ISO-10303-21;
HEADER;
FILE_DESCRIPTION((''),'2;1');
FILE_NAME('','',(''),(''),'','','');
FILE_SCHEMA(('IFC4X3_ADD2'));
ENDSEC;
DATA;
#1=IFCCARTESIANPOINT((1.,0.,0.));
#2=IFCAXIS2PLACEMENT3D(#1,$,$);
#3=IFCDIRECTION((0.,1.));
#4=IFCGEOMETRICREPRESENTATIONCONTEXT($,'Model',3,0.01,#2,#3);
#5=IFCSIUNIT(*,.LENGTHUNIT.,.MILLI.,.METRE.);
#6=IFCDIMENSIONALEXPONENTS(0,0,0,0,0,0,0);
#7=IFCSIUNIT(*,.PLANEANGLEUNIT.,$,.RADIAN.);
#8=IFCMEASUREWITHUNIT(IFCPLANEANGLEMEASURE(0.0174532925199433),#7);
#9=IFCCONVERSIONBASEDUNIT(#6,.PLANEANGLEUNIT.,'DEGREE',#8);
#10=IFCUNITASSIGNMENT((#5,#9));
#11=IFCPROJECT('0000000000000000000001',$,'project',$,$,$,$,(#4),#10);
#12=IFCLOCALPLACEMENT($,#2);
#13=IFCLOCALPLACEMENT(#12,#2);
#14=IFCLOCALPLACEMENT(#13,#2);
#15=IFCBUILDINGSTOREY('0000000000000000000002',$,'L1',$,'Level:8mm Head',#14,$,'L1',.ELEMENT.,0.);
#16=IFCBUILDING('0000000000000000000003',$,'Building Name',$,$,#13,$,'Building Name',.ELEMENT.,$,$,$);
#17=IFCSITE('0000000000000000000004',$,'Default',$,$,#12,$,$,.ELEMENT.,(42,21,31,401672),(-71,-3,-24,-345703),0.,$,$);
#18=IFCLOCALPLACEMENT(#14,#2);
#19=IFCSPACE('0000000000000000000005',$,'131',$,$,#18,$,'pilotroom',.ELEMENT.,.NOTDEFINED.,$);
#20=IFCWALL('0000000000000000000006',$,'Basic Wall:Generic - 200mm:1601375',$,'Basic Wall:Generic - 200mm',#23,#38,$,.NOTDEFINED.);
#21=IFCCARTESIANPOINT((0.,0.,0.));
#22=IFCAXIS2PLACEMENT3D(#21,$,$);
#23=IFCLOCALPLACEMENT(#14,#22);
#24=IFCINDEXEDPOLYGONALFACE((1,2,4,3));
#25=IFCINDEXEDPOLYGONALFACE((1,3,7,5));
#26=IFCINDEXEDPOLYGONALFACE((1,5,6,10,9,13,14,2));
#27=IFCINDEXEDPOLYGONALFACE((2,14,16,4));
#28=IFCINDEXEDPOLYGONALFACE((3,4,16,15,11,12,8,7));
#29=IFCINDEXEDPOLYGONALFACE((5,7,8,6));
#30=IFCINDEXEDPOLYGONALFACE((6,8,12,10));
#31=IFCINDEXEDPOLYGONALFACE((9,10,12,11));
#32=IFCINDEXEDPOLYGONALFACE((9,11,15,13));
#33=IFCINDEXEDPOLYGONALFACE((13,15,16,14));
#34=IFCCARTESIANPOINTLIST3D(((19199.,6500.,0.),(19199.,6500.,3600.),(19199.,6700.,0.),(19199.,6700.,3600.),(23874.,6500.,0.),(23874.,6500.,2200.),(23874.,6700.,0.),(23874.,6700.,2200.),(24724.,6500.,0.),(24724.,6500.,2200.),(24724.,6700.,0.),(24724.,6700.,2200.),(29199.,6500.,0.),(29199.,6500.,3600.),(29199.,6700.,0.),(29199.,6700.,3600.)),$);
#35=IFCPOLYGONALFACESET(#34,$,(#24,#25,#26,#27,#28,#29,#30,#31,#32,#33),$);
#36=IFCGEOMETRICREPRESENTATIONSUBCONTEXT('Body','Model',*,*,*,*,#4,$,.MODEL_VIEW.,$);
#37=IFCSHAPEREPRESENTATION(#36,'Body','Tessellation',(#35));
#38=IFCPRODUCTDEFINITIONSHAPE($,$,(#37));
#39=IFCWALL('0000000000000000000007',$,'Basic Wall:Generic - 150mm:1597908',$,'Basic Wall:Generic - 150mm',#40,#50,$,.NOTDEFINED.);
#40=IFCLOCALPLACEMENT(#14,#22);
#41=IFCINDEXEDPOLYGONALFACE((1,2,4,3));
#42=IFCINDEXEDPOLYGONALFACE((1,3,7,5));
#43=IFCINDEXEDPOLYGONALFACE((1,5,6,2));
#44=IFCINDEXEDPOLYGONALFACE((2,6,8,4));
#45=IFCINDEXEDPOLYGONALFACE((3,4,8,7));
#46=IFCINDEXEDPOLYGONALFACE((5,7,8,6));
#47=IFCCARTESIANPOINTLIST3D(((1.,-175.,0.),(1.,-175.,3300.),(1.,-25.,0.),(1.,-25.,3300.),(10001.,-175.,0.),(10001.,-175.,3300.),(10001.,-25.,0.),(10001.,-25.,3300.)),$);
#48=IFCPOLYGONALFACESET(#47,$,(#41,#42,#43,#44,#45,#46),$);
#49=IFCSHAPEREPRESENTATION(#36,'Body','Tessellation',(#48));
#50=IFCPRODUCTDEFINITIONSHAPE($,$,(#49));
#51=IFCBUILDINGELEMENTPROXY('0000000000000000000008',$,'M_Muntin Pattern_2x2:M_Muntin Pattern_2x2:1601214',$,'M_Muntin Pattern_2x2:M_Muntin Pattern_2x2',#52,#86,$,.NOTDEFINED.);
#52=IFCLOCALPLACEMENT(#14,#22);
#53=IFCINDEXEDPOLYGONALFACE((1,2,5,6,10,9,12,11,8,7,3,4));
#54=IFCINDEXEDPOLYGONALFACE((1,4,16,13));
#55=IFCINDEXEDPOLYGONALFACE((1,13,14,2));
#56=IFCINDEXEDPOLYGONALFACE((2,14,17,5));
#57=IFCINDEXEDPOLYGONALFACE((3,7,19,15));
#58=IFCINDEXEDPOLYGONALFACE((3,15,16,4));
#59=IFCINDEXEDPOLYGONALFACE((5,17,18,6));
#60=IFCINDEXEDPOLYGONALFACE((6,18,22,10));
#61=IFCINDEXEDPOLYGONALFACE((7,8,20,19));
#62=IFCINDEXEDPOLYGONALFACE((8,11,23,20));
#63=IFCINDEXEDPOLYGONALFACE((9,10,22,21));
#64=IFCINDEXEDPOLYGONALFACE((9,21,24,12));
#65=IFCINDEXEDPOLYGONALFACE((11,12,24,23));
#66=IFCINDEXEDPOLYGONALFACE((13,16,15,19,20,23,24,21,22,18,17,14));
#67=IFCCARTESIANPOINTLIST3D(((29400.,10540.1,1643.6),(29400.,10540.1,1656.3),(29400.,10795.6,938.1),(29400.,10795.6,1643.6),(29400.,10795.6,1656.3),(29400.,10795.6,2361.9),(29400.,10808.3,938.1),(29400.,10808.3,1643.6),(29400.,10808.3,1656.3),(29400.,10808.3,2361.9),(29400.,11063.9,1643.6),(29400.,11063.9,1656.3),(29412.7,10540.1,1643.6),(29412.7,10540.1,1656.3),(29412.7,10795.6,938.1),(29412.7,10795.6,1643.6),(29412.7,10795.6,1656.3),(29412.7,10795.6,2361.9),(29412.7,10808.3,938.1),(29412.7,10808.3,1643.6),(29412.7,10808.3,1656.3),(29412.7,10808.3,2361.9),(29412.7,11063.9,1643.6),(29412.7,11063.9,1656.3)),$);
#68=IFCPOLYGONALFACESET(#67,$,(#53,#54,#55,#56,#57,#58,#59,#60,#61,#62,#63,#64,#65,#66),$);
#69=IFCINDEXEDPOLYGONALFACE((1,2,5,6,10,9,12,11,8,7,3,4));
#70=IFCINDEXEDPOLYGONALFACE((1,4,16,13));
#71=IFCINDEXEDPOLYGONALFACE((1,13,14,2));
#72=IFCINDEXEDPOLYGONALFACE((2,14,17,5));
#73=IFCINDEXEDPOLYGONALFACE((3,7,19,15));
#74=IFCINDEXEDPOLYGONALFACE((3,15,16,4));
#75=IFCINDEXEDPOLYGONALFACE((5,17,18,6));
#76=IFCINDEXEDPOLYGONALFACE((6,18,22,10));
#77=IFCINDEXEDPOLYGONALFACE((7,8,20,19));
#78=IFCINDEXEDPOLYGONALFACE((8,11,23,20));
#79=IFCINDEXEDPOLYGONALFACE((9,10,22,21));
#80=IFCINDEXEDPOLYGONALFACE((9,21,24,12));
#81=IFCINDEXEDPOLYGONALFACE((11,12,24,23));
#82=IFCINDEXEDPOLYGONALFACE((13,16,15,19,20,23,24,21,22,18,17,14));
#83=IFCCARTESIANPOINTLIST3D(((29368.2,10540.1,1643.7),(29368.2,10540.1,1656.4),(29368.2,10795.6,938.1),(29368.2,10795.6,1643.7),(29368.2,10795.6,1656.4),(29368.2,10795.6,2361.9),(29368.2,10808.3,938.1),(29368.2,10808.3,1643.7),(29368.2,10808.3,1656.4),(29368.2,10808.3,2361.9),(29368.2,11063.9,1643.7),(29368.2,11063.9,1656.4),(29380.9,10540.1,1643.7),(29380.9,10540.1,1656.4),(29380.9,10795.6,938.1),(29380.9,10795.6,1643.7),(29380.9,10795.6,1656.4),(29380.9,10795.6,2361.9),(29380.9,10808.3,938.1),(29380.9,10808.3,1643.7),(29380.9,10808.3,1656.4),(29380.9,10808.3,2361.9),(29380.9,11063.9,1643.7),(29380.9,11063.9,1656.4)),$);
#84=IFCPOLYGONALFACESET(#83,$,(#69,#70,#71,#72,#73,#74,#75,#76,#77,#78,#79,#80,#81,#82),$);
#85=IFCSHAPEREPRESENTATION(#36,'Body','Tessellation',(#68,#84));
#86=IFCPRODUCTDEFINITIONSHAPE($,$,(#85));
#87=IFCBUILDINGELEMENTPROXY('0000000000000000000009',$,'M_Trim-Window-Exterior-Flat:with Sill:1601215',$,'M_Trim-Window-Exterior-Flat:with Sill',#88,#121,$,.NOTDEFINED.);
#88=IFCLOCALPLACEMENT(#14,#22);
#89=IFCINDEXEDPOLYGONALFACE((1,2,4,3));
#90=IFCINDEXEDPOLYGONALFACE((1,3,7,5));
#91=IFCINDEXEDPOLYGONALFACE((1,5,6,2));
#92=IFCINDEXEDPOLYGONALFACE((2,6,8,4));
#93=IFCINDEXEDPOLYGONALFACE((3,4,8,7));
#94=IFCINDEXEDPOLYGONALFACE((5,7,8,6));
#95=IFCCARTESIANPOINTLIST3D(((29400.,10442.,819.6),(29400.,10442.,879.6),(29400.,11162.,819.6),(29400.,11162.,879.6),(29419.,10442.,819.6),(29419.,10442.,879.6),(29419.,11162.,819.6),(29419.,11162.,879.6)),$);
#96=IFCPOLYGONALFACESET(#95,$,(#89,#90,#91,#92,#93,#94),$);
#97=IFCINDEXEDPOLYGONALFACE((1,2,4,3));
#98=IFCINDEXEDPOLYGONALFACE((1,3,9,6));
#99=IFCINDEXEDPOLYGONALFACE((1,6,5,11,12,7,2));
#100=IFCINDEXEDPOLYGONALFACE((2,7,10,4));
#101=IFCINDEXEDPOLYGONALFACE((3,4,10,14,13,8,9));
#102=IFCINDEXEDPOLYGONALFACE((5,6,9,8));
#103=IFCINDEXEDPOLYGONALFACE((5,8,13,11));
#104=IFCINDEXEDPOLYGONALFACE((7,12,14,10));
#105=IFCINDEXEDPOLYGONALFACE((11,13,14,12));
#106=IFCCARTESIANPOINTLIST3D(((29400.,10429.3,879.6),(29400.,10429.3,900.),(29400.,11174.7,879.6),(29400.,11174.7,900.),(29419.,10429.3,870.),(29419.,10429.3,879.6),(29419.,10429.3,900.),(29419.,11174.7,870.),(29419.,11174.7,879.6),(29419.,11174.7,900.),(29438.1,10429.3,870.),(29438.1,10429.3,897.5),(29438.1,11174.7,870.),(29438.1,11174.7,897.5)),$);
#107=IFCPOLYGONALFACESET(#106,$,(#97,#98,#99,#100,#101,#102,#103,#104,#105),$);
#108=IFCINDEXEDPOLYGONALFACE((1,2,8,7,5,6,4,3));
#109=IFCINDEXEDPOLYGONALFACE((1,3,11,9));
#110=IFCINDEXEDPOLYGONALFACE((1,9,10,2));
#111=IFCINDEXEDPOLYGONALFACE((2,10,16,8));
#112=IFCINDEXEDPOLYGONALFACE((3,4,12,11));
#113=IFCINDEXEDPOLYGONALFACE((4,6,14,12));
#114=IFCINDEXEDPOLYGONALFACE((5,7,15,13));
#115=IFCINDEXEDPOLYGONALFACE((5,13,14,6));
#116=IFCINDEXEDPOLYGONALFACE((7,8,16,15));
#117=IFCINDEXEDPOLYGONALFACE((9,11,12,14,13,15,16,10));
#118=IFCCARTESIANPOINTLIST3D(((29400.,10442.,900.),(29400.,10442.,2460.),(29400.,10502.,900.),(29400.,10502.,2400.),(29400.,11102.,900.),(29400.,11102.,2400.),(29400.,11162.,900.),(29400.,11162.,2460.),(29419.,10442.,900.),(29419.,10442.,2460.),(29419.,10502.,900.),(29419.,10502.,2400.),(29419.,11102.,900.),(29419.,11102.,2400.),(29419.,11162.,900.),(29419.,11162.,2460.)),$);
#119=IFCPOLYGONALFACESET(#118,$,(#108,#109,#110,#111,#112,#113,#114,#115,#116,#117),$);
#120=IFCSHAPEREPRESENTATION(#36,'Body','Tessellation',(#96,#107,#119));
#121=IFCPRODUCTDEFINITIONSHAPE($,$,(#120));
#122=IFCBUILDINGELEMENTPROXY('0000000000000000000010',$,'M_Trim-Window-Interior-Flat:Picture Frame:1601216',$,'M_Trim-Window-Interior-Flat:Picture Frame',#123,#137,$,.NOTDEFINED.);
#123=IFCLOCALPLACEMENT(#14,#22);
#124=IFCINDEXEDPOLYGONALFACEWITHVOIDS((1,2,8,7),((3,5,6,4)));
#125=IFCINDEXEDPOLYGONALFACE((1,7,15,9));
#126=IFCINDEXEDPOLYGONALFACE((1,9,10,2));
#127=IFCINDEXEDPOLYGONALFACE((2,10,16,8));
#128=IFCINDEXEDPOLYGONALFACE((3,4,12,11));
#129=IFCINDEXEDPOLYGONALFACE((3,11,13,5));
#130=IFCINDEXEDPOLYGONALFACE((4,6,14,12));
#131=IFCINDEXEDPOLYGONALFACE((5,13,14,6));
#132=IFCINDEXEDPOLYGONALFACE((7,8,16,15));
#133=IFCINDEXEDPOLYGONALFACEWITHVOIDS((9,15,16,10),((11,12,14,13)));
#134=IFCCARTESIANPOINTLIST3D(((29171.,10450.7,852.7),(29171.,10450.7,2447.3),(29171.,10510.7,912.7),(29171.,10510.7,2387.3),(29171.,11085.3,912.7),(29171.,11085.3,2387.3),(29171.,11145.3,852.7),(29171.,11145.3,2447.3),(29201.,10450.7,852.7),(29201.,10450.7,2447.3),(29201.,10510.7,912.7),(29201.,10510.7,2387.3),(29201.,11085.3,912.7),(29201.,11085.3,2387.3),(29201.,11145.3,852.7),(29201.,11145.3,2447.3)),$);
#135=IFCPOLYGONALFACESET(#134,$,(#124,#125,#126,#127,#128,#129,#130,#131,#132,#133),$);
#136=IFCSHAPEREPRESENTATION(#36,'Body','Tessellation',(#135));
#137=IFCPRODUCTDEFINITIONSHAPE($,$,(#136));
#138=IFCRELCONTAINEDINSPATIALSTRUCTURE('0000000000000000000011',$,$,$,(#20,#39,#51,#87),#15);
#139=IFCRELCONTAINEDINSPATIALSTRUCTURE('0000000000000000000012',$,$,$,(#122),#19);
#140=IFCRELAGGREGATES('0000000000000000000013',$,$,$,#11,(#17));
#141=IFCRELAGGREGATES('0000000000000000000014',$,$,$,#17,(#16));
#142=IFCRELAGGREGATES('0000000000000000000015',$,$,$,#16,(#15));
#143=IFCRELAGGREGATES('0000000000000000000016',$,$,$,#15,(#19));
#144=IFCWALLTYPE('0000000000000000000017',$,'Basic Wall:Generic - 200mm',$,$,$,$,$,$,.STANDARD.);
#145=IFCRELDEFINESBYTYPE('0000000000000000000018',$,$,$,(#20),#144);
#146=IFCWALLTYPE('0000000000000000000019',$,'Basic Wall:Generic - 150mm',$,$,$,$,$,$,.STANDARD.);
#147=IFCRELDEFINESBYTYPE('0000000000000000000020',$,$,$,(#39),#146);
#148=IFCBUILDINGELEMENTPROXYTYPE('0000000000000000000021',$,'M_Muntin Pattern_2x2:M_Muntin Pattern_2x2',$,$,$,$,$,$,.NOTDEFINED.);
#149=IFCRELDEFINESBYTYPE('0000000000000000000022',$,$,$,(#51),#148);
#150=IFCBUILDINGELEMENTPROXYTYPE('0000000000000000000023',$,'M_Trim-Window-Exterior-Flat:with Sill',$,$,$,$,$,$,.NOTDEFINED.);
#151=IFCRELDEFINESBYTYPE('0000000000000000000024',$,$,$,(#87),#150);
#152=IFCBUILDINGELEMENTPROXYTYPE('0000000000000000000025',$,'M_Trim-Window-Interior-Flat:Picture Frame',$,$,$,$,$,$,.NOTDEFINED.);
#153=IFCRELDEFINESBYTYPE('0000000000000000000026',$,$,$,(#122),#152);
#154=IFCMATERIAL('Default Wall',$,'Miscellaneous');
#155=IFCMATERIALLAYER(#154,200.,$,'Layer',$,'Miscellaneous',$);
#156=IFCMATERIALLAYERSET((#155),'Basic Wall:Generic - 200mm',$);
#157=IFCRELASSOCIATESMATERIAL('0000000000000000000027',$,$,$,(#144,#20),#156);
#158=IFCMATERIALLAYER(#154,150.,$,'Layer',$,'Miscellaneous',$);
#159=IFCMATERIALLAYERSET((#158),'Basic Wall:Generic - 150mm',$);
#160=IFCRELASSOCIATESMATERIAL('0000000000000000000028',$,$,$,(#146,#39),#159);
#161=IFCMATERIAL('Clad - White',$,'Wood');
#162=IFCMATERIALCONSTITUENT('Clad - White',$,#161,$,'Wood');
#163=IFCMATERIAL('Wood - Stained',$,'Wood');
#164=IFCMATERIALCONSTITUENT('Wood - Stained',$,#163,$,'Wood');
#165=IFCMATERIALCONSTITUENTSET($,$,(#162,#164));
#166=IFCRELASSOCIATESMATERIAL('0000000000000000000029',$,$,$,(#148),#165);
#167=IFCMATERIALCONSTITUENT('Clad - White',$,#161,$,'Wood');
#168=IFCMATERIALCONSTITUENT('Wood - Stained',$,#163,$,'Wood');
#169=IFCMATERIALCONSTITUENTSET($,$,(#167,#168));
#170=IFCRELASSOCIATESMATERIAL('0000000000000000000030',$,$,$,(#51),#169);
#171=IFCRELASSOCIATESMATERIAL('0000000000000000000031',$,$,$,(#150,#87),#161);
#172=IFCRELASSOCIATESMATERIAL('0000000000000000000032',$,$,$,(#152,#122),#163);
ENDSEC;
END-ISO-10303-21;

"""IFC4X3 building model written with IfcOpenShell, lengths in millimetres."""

from ifc_helpers import new_model, entity, si_unit, converted_unit, direction, frame, frame_2d, place, context, subcontext, project, spatial, polyline, rectangle, outline, extrude, source, transform, mapped, material, layer, layer_set, constituent, constituent_set, type_object, type_shapes, element, save


model = new_model("IFC4X3")

# Units and contexts
model_context = context("Model", 3, precision=0.01, world=frame((1.0, 0.0, 0.0)), true_north=direction((0.0, 1.0)))
body_context = subcontext(model_context, "Body", "Model", "MODEL_VIEW")
ifc_project = project(units=[si_unit("LENGTHUNIT", "METRE", prefix="MILLI"), converted_unit("PLANEANGLEUNIT", "DEGREE", entity("IfcPlaneAngleMeasure", 0.0174532925199433), si_unit("PLANEANGLEUNIT", "RADIAN"), dimensions=[0, 0, 0, 0, 0, 0, 0])], contexts=[model_context])

# Site, building, storey
site_placement = place(None, frame((1.0, 0.0, 0.0)))
site = spatial("IfcSite", under=ifc_project, at=site_placement, Name="Default", CompositionType="ELEMENT", RefLatitude=(42, 21, 31, 401672), RefLongitude=(-71, -3, -24, -345703), RefElevation=0.0)
building_placement = place(site_placement, frame((1.0, 0.0, 0.0)))
building = spatial("IfcBuilding", under=site, at=building_placement, Name="Building Name", LongName="Building Name", CompositionType="ELEMENT")
storey_placement = place(building_placement, frame((1.0, 0.0, 0.0)))
storey = spatial("IfcBuildingStorey", under=building, at=storey_placement, Name="L1", ObjectType="Level:8mm Head", LongName="L1", CompositionType="ELEMENT", Elevation=0.0)

# Shared definitions
ifc_material_1 = material(Name="Default Wall", Category="Miscellaneous")
ifc_layer_1 = layer(ifc_material_1, 200.0, Name="Layer", Category="Miscellaneous")
ifc_layer_set_1 = layer_set([ifc_layer_1], Name="Basic Wall:Generic - 200mm")
wall_type_1 = type_object("IfcWallType", Name="Basic Wall:Generic - 200mm", PredefinedType="STANDARD", material=ifc_layer_set_1)

# Wall, opening
wall_1_placement = place(storey_placement, frame((29200.0, 6600.0, 0.0), z_axis=(0.0, 0.0, 1.0), x_axis=(-1.0, 0.0, 0.0)))
wall_1 = element("IfcWall", 1, at=wall_1_placement, inside=storey, type_object=wall_type_1, material=ifc_layer_set_1, Name="Basic Wall:Generic - 200mm:1601375", ObjectType="Basic Wall:Generic - 200mm", PredefinedType="NOTDEFINED", context=body_context, shape_type="SweptSolid", body=[
    extrude(rectangle(XDim=10000.0, YDim=200.0, at=frame_2d((5000.0, 0.0), x_axis=(1.0, 0.0))), frame((1.0, 0.0, 0.0)), (0.0, 0.0, 1.0), 3600.0),
])
opening_1_placement = place(wall_1_placement, frame((5325.0, 100.0, 0.0)))
element("IfcOpeningElement", 2, at=opening_1_placement, cuts=wall_1, PredefinedType="OPENING", context=body_context, shape_type="SweptSolid", body=[
    extrude(rectangle(XDim=2200.0, YDim=850.0, at=frame_2d((1100.0, 425.0), x_axis=(1.0, 0.0))), frame((1.0, 0.0, 0.0), z_axis=(0.0, -1.0, 0.0), x_axis=(0.0, 0.0, 1.0)), (0.0, 0.0, 1.0), 200.0),
])

# Wall
ifc_layer_2 = layer(ifc_material_1, 150.0, Name="Layer", Category="Miscellaneous")
ifc_layer_set_2 = layer_set([ifc_layer_2], Name="Basic Wall:Generic - 150mm")
wall_type_2 = type_object("IfcWallType", Name="Basic Wall:Generic - 150mm", PredefinedType="STANDARD", material=ifc_layer_set_2)
wall_2_placement = place(storey_placement, frame((0.0, -100.0, 0.0)))
element("IfcWall", 3, at=wall_2_placement, inside=storey, type_object=wall_type_2, material=ifc_layer_set_2, Name="Basic Wall:Generic - 150mm:1597908", ObjectType="Basic Wall:Generic - 150mm", PredefinedType="NOTDEFINED", context=body_context, shape_type="SweptSolid", body=[
    extrude(rectangle(XDim=10000.0, YDim=150.0, at=frame_2d((5000.0, 0.0), x_axis=(-1.0, 0.0))), frame((1.0, 0.0, 0.0)), (0.0, 0.0, 1.0), 3300.0),
])

# Building element proxies
ifc_material_2 = material(Name="Clad - White", Category="Wood")
ifc_constituent_1 = constituent(ifc_material_2, Name="Clad - White", Category="Wood")
ifc_material_3 = material(Name="Wood - Stained", Category="Wood")
ifc_constituent_2 = constituent(ifc_material_3, Name="Wood - Stained", Category="Wood")
ifc_constituent_set_1 = constituent_set(constituents=[ifc_constituent_1, ifc_constituent_2])
ifc_constituent_3 = constituent(ifc_material_2, Name="Clad - White", Category="Wood")
ifc_constituent_4 = constituent(ifc_material_3, Name="Wood - Stained", Category="Wood")
ifc_constituent_set_2 = constituent_set(constituents=[ifc_constituent_3, ifc_constituent_4])
building_element_proxy_type_1 = type_object("IfcBuildingElementProxyType", Name="M_Muntin Pattern_2x2:M_Muntin Pattern_2x2", PredefinedType="NOTDEFINED", material=ifc_constituent_set_2)
shared_shape_1 = source(frame((1.0, 0.0, 0.0)), body_context, "Body", "SweptSolid", [
    extrude(outline(polyline([(6.4, -6.4), (711.9, -6.4), (711.9, 6.3), (6.4, 6.3), (6.4, 261.9), (-6.3, 261.9), (-6.3, 6.3), (-711.9, 6.3), (-711.9, -6.4), (-6.3, -6.4), (-6.3, -261.9), (6.4, -261.9), (6.4, -6.4)])), frame((0.0, -22.2, 711.9), z_axis=(0.0, 1.0, 0.0), x_axis=(0.0, 0.0, 1.0)), (0.0, 0.0, 1.0), 12.7),
    extrude(outline(polyline([(6.4, -6.4), (711.9, -6.4), (711.9, 6.3), (6.4, 6.3), (6.4, 261.9), (-6.3, 261.9), (-6.3, 6.3), (-711.9, 6.3), (-711.9, -6.4), (-6.3, -6.4), (-6.3, -261.9), (6.4, -261.9), (6.4, -6.4)])), frame((0.0, 9.5, 711.9), z_axis=(0.0, 1.0, 0.0), x_axis=(0.0, 0.0, 1.0)), (0.0, 0.0, 1.0), 12.7),
])
type_shapes(building_element_proxy_type_1, [shared_shape_1])
proxy_1_placement = place(storey_placement, frame((29390.5, 10800.0, 938.1), z_axis=(0.0, 0.0, 1.0), x_axis=(0.0, 1.0, 0.0)))
element("IfcBuildingElementProxy", 4, at=proxy_1_placement, inside=storey, type_object=building_element_proxy_type_1, material=ifc_constituent_set_1, Name="M_Muntin Pattern_2x2:M_Muntin Pattern_2x2:1601214", ObjectType="M_Muntin Pattern_2x2:M_Muntin Pattern_2x2", PredefinedType="NOTDEFINED", context=body_context, shape_type="MappedRepresentation", body=[
    mapped(shared_shape_1, transform((1.0, 0.0, 0.0), scale=1.0)),
])
building_element_proxy_type_2 = type_object("IfcBuildingElementProxyType", Name="M_Trim-Window-Exterior-Flat:with Sill", PredefinedType="NOTDEFINED", material=ifc_material_2)
shared_shape_2 = source(frame((1.0, 0.0, 0.0)), body_context, "Body", "SweptSolid", [
    extrude(rectangle(XDim=720.0, YDim=60.0, at=frame_2d((0.0, 0.0), x_axis=(1.0, 0.0))), frame((0.0, -1550.4, 0.0), z_axis=(0.0, 0.0, 1.0), x_axis=(-1.0, 0.0, 0.0)), (0.0, 0.0, 1.0), 19.1),
    extrude(outline(polyline([(-19.0, -15.2), (0.0, -15.2), (0.0, -5.7), (19.0, -5.7), (19.0, 14.8), (0.0, 14.8), (-19.0, 12.3), (-19.0, -15.2)])), frame((-372.7, -1514.8, 19.0), z_axis=(1.0, 0.0, 0.0), x_axis=(0.0, 0.0, -1.0)), (0.0, 0.0, 1.0), 745.4),
    extrude(outline(polyline([(-795.0, -360.0), (765.0, -360.0), (765.0, -300.0), (-735.0, -300.0), (-735.0, 300.0), (765.0, 300.0), (765.0, 360.0), (-795.0, 360.0), (-795.0, -360.0)])), frame((0.0, -735.0, 0.0), z_axis=(0.0, 0.0, 1.0), x_axis=(0.0, -1.0, 0.0)), (0.0, 0.0, 1.0), 19.1),
])
type_shapes(building_element_proxy_type_2, [shared_shape_2])
proxy_2_placement = place(storey_placement, frame((29400.0, 10800.0, 2400.0), z_axis=(1.0, 0.0, 0.0), x_axis=(0.0, 1.0, 0.0)))
element("IfcBuildingElementProxy", 5, at=proxy_2_placement, inside=storey, type_object=building_element_proxy_type_2, material=ifc_material_2, Name="M_Trim-Window-Exterior-Flat:with Sill:1601215", ObjectType="M_Trim-Window-Exterior-Flat:with Sill", PredefinedType="NOTDEFINED", context=body_context, shape_type="MappedRepresentation", body=[
    mapped(shared_shape_2, transform((1.0, 0.0, 0.0), scale=1.0)),
])

# Shared definitions
space_placement = place(storey_placement, frame((1.0, 0.0, 0.0)))
space = spatial("IfcSpace", under=storey, at=space_placement, Name="131", LongName="pilotroom", CompositionType="ELEMENT", PredefinedType="NOTDEFINED")

# Building element proxy
building_element_proxy_type_3 = type_object("IfcBuildingElementProxyType", Name="M_Trim-Window-Interior-Flat:Picture Frame", PredefinedType="NOTDEFINED", material=ifc_material_3)
shared_shape_3 = source(frame((1.0, 0.0, 0.0)), body_context, "Body", "SweptSolid", [
    extrude(outline(polyline([(-347.3, -797.3), (347.3, -797.3), (347.3, 797.3), (-347.3, 797.3), (-347.3, -797.3)]), holes=[polyline([(-287.3, -737.3), (-287.3, 737.3), (287.3, 737.3), (287.3, -737.3), (-287.3, -737.3)])]), frame((0.0, -750.0, 0.0), z_axis=(0.0, 0.0, 1.0), x_axis=(-1.0, 0.0, 0.0)), (0.0, 0.0, 1.0), 30.0),
])
type_shapes(building_element_proxy_type_3, [shared_shape_3])
proxy_3_placement = place(space_placement, frame((29200.0, 10800.0, 2400.0), z_axis=(-1.0, 0.0, 0.0), x_axis=(0.0, -1.0, 0.0)))
element("IfcBuildingElementProxy", 6, at=proxy_3_placement, inside=space, type_object=building_element_proxy_type_3, material=ifc_material_3, Name="M_Trim-Window-Interior-Flat:Picture Frame:1601216", ObjectType="M_Trim-Window-Interior-Flat:Picture Frame", PredefinedType="NOTDEFINED", context=body_context, shape_type="MappedRepresentation", body=[
    mapped(shared_shape_3, transform((1.0, 0.0, 0.0), scale=1.0)),
])

save(model, "model.ifc")
